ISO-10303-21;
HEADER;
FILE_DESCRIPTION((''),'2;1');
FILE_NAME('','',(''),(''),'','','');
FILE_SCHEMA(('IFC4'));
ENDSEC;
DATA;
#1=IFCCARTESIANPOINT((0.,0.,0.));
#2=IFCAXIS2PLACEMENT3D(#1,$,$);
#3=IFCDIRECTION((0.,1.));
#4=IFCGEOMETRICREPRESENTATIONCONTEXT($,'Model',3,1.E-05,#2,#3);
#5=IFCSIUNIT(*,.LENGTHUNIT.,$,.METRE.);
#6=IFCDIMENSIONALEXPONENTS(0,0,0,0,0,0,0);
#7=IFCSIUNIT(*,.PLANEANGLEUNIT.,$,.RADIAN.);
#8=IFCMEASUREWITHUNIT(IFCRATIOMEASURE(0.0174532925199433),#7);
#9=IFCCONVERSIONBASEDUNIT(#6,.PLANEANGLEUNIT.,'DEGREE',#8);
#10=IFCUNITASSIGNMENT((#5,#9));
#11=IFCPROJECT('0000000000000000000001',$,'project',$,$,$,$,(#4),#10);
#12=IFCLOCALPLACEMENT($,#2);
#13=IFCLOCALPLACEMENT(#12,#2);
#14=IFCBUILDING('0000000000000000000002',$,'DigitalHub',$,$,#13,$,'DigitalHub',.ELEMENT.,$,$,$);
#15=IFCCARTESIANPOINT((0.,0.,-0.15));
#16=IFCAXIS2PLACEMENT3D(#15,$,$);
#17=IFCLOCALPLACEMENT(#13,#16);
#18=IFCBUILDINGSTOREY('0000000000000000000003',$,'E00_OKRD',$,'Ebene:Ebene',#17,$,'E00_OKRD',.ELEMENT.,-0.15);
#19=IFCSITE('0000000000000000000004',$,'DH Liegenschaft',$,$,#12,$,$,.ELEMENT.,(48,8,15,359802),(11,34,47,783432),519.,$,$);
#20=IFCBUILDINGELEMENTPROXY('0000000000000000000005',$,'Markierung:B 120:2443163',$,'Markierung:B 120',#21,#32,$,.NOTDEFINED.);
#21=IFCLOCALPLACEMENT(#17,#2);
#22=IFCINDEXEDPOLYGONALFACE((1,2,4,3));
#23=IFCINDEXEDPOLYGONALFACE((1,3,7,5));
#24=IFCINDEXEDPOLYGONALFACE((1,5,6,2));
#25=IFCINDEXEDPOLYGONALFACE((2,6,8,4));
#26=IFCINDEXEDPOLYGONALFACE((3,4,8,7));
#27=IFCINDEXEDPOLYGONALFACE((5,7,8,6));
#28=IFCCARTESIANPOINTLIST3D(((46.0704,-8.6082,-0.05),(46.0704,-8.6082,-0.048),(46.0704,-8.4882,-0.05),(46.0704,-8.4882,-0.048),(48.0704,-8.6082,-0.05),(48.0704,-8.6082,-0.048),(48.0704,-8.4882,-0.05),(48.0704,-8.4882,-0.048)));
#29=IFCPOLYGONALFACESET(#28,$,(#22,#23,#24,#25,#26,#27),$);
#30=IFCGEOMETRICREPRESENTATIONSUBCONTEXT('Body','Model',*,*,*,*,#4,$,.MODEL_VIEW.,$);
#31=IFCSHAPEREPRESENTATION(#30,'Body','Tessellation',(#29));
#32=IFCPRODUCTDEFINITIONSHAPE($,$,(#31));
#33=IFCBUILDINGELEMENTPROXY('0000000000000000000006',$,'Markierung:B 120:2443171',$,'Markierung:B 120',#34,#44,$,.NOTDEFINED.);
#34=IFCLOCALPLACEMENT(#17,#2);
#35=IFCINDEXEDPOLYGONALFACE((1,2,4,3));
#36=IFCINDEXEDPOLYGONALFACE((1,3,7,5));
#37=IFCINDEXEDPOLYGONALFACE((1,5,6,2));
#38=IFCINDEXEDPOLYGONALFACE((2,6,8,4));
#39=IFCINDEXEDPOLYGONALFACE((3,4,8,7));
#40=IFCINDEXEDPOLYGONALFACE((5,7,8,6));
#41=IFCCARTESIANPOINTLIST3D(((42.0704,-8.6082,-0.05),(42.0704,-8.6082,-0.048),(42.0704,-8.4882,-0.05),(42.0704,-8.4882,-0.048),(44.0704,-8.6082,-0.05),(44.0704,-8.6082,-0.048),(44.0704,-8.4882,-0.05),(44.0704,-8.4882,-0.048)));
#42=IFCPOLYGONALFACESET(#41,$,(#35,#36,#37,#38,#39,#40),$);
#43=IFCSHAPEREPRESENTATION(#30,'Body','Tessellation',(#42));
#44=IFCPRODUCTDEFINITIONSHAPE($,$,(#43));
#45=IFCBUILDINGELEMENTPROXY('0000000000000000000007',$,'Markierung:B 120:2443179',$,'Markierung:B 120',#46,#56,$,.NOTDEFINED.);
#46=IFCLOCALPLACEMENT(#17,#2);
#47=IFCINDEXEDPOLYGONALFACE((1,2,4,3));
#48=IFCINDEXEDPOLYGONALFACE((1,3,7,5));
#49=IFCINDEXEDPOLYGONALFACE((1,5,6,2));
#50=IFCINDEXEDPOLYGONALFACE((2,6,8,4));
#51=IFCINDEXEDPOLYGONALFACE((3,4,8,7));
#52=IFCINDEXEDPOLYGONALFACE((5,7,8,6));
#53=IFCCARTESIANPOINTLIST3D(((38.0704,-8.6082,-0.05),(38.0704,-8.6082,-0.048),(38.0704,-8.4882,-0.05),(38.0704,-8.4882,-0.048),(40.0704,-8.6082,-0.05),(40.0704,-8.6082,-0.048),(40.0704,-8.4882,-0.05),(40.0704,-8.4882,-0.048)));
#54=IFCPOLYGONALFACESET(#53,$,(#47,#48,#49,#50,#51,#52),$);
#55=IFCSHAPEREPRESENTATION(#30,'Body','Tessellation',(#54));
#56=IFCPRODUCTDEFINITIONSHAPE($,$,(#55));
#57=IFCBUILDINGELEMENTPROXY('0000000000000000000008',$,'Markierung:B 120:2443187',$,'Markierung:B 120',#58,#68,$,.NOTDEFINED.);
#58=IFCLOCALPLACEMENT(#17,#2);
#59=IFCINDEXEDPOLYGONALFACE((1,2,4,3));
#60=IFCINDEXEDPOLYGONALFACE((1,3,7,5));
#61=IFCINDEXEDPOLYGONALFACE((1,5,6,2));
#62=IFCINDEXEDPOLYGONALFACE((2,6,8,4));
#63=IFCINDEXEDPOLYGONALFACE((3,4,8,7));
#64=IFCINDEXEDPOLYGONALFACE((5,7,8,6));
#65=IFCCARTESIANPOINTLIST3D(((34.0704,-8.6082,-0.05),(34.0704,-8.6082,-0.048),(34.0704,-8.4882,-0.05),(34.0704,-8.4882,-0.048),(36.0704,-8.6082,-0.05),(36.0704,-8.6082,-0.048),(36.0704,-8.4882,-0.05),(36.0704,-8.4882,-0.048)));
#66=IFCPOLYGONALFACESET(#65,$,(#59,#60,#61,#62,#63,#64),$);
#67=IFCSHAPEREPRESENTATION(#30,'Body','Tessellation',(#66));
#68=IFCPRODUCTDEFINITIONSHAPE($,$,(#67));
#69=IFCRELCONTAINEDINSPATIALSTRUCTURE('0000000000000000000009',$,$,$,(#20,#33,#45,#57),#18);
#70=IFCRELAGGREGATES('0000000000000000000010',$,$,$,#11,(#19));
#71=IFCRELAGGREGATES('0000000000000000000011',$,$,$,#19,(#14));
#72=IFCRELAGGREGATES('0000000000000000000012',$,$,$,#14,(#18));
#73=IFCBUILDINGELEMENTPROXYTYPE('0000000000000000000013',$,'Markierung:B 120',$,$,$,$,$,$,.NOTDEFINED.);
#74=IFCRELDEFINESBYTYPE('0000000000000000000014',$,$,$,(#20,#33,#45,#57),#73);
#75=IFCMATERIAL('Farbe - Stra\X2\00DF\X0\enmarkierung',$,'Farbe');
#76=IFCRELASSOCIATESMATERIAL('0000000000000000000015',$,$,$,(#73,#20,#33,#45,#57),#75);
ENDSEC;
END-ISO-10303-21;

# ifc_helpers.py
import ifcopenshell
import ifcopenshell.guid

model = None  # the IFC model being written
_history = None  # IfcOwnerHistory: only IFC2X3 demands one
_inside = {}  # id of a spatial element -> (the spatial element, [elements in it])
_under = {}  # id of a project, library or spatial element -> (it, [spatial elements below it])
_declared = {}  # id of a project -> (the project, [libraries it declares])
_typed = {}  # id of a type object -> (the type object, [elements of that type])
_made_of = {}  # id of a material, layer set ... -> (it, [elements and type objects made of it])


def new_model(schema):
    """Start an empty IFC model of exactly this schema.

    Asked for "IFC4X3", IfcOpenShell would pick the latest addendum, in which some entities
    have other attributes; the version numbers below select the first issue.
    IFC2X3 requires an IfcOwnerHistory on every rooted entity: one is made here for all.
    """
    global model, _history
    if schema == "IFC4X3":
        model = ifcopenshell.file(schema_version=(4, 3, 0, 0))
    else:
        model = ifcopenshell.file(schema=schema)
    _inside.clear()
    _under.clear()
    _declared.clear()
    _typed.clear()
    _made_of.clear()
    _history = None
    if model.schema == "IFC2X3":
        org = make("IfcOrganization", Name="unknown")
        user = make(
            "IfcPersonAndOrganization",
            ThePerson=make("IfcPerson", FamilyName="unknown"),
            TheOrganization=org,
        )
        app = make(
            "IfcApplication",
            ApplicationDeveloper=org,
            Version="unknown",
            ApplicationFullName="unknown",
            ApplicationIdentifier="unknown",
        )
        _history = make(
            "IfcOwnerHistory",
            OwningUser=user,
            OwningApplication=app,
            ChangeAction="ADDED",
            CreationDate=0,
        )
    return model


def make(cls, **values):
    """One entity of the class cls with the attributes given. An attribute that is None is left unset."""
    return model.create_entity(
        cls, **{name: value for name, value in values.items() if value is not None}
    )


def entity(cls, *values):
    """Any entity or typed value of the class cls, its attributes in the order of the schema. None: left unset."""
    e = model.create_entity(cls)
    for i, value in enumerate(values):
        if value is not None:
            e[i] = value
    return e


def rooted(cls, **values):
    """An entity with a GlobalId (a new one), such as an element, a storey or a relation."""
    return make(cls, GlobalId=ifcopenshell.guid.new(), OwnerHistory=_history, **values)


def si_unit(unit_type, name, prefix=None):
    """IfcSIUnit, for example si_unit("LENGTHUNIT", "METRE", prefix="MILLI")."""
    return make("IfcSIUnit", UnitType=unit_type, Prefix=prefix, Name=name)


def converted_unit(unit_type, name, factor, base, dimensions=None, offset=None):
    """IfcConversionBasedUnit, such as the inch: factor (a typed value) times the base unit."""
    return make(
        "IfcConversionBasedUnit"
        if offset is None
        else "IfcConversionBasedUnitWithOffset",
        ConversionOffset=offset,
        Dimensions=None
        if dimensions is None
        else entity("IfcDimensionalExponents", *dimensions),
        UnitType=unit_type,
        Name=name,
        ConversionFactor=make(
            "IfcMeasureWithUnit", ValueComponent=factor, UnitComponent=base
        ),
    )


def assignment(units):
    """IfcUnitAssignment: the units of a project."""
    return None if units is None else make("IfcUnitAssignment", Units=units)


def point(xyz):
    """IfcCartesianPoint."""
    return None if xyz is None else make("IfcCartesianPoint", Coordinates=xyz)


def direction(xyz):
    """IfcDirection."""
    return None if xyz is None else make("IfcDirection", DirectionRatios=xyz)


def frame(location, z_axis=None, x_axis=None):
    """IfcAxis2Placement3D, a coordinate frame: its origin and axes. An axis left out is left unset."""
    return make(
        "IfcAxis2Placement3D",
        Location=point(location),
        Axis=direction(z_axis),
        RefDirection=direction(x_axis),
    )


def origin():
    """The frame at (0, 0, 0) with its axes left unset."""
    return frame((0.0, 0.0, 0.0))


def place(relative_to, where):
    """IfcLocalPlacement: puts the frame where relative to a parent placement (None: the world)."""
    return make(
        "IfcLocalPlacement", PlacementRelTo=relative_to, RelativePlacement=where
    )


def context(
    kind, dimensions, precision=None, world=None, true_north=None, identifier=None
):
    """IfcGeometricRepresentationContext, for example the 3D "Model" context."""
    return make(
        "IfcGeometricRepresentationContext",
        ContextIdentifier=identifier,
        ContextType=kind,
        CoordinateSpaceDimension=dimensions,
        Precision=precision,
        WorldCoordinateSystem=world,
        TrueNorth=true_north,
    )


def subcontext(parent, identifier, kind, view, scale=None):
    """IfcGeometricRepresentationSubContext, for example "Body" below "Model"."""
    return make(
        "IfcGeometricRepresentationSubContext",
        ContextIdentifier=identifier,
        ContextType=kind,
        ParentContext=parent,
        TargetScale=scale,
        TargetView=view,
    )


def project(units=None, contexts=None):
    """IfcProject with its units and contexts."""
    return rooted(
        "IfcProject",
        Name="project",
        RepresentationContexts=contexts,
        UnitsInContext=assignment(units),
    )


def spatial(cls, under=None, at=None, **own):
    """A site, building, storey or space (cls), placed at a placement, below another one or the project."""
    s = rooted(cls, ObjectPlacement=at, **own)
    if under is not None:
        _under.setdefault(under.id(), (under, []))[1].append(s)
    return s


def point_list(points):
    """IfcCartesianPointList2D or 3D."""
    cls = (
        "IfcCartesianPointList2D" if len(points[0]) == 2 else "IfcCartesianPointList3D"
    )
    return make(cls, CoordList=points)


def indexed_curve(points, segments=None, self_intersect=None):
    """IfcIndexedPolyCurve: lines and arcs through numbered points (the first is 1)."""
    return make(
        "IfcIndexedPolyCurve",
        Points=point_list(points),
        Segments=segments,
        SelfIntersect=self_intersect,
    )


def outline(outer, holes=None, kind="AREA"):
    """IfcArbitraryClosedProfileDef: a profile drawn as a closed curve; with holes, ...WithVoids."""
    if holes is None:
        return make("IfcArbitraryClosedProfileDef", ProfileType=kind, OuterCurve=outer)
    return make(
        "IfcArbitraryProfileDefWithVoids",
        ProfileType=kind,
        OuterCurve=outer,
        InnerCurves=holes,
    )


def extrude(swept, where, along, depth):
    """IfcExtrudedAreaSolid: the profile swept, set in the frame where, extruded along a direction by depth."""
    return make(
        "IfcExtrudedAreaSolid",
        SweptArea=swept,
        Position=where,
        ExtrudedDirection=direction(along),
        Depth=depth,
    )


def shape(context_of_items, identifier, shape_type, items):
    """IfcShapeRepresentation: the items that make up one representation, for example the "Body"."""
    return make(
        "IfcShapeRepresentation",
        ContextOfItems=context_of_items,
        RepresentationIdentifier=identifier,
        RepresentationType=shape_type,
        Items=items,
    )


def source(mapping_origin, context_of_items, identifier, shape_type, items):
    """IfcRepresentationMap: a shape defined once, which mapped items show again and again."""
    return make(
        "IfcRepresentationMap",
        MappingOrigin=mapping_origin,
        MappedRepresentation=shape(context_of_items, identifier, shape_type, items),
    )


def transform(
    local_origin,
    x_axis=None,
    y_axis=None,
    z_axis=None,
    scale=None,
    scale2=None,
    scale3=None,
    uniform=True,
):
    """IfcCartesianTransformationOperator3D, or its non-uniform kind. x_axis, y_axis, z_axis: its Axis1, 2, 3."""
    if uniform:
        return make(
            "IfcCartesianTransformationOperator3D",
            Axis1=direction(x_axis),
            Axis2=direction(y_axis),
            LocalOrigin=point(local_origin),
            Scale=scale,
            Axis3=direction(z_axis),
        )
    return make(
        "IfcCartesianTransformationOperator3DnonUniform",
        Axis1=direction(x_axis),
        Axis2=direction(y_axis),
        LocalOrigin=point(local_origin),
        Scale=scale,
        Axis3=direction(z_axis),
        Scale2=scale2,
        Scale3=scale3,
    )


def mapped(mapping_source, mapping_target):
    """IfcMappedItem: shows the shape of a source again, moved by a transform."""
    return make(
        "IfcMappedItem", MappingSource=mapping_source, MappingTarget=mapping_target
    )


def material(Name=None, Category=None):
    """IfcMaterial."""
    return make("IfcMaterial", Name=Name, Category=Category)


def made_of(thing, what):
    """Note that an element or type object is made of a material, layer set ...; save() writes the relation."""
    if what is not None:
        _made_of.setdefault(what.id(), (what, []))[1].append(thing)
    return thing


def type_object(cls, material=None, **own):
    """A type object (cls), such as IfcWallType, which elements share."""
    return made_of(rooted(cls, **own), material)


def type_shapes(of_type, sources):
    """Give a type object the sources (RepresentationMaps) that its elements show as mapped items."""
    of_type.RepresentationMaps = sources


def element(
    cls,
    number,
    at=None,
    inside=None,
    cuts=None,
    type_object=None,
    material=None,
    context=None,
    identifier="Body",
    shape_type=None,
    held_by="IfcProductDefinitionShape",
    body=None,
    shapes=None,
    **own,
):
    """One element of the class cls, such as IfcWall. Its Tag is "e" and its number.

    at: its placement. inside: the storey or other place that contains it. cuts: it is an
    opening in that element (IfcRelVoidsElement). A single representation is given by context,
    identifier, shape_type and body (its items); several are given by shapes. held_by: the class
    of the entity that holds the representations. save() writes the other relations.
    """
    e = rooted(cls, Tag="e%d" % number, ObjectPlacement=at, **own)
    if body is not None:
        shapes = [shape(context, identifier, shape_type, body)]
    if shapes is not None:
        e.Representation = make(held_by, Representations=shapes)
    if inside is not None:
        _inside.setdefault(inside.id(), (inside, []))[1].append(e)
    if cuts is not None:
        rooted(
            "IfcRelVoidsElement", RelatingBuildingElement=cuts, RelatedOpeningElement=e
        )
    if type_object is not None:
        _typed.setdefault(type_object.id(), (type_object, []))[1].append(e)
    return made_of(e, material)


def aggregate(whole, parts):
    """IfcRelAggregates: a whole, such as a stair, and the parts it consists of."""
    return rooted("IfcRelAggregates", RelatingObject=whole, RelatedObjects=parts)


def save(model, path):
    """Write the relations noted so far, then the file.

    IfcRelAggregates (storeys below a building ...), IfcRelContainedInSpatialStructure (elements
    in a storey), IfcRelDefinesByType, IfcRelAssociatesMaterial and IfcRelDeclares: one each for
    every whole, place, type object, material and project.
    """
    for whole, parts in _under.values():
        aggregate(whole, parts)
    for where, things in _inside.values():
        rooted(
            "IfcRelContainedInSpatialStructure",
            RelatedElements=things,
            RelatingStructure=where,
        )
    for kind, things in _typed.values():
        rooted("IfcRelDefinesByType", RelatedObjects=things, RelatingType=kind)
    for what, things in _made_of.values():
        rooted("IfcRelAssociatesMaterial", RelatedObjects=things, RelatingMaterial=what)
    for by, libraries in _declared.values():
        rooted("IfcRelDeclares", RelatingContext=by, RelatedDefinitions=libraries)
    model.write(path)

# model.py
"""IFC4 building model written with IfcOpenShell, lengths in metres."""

from ifc_helpers import new_model, entity, si_unit, converted_unit, direction, frame, origin, place, context, subcontext, project, spatial, indexed_curve, outline, extrude, source, transform, mapped, material, type_object, type_shapes, element, save


model = new_model("IFC4")

# Units and contexts
model_context = context("Model", 3, precision=1e-05, world=origin(), true_north=direction((0.0, 1.0)))
body_context = subcontext(model_context, "Body", "Model", "MODEL_VIEW")
ifc_project = project(units=[si_unit("LENGTHUNIT", "METRE"), converted_unit("PLANEANGLEUNIT", "DEGREE", entity("IfcRatioMeasure", 0.0174532925199433), si_unit("PLANEANGLEUNIT", "RADIAN"), dimensions=[0, 0, 0, 0, 0, 0, 0])], contexts=[model_context])

# Site, building, storey
site_placement = place(None, frame((0.0, 0.0, 0.0)))
site = spatial("IfcSite", under=ifc_project, at=site_placement, Name="DH Liegenschaft", CompositionType="ELEMENT", RefLatitude=(48, 8, 15, 359802), RefLongitude=(11, 34, 47, 783432), RefElevation=519.0)
building_placement = place(site_placement, origin())
building = spatial("IfcBuilding", under=site, at=building_placement, Name="DigitalHub", LongName="DigitalHub", CompositionType="ELEMENT")
storey_placement = place(building_placement, frame((0.0, 0.0, -0.15)))
storey = spatial("IfcBuildingStorey", under=building, at=storey_placement, Name="E00_OKRD", ObjectType="Ebene:Ebene", LongName="E00_OKRD", CompositionType="ELEMENT", Elevation=-0.15)

# Building element proxies
ifc_material_1 = material(Name="Farbe - Straßenmarkierung", Category="Farbe")
building_element_proxy_type_1 = type_object("IfcBuildingElementProxyType", Name="Markierung:B 120", PredefinedType="NOTDEFINED", material=ifc_material_1)
shared_shape_1 = source(origin(), body_context, "Body", "SweptSolid", [
    extrude(outline(indexed_curve([(-0.06, -1.0), (0.06, -1.0), (0.06, 1.0), (-0.06, 1.0), (-0.06, -1.0)], self_intersect=False)), frame((0.06, 1.0, 0.0), z_axis=(0.0, 0.0, 1.0), x_axis=(-1.0, 0.0, 0.0)), (0.0, 0.0, 1.0), 0.002),
])
type_shapes(building_element_proxy_type_1, [shared_shape_1])
for number, where, z_axis, x_axis, name in (
    (1, (48.0704, -8.6082, -0.05), (0.0, 0.0, 1.0), (0.0, 1.0, 0.0), "Markierung:B 120:2443163"),
    (2, (44.0704, -8.6082, -0.05), (0.0, 0.0, 1.0), (0.0, 1.0, 0.0), "Markierung:B 120:2443171"),
    (3, (40.0704, -8.6082, -0.05), (0.0, 0.0, 1.0), (0.0, 1.0, 0.0), "Markierung:B 120:2443179"),
    (4, (36.0704, -8.6082, -0.05), (0.0, 0.0, 1.0), (0.0, 1.0, 0.0), "Markierung:B 120:2443187"),
):
    element("IfcBuildingElementProxy", number, at=place(storey_placement, frame(where, z_axis=z_axis, x_axis=x_axis)), inside=storey, type_object=building_element_proxy_type_1, material=ifc_material_1, Name=name, ObjectType="Markierung:B 120", PredefinedType="NOTDEFINED", context=body_context, shape_type="MappedRepresentation", body=[
        mapped(shared_shape_1, transform((0.0, 0.0, 0.0), scale=1.0)),
    ])

save(model, "model.ifc")
